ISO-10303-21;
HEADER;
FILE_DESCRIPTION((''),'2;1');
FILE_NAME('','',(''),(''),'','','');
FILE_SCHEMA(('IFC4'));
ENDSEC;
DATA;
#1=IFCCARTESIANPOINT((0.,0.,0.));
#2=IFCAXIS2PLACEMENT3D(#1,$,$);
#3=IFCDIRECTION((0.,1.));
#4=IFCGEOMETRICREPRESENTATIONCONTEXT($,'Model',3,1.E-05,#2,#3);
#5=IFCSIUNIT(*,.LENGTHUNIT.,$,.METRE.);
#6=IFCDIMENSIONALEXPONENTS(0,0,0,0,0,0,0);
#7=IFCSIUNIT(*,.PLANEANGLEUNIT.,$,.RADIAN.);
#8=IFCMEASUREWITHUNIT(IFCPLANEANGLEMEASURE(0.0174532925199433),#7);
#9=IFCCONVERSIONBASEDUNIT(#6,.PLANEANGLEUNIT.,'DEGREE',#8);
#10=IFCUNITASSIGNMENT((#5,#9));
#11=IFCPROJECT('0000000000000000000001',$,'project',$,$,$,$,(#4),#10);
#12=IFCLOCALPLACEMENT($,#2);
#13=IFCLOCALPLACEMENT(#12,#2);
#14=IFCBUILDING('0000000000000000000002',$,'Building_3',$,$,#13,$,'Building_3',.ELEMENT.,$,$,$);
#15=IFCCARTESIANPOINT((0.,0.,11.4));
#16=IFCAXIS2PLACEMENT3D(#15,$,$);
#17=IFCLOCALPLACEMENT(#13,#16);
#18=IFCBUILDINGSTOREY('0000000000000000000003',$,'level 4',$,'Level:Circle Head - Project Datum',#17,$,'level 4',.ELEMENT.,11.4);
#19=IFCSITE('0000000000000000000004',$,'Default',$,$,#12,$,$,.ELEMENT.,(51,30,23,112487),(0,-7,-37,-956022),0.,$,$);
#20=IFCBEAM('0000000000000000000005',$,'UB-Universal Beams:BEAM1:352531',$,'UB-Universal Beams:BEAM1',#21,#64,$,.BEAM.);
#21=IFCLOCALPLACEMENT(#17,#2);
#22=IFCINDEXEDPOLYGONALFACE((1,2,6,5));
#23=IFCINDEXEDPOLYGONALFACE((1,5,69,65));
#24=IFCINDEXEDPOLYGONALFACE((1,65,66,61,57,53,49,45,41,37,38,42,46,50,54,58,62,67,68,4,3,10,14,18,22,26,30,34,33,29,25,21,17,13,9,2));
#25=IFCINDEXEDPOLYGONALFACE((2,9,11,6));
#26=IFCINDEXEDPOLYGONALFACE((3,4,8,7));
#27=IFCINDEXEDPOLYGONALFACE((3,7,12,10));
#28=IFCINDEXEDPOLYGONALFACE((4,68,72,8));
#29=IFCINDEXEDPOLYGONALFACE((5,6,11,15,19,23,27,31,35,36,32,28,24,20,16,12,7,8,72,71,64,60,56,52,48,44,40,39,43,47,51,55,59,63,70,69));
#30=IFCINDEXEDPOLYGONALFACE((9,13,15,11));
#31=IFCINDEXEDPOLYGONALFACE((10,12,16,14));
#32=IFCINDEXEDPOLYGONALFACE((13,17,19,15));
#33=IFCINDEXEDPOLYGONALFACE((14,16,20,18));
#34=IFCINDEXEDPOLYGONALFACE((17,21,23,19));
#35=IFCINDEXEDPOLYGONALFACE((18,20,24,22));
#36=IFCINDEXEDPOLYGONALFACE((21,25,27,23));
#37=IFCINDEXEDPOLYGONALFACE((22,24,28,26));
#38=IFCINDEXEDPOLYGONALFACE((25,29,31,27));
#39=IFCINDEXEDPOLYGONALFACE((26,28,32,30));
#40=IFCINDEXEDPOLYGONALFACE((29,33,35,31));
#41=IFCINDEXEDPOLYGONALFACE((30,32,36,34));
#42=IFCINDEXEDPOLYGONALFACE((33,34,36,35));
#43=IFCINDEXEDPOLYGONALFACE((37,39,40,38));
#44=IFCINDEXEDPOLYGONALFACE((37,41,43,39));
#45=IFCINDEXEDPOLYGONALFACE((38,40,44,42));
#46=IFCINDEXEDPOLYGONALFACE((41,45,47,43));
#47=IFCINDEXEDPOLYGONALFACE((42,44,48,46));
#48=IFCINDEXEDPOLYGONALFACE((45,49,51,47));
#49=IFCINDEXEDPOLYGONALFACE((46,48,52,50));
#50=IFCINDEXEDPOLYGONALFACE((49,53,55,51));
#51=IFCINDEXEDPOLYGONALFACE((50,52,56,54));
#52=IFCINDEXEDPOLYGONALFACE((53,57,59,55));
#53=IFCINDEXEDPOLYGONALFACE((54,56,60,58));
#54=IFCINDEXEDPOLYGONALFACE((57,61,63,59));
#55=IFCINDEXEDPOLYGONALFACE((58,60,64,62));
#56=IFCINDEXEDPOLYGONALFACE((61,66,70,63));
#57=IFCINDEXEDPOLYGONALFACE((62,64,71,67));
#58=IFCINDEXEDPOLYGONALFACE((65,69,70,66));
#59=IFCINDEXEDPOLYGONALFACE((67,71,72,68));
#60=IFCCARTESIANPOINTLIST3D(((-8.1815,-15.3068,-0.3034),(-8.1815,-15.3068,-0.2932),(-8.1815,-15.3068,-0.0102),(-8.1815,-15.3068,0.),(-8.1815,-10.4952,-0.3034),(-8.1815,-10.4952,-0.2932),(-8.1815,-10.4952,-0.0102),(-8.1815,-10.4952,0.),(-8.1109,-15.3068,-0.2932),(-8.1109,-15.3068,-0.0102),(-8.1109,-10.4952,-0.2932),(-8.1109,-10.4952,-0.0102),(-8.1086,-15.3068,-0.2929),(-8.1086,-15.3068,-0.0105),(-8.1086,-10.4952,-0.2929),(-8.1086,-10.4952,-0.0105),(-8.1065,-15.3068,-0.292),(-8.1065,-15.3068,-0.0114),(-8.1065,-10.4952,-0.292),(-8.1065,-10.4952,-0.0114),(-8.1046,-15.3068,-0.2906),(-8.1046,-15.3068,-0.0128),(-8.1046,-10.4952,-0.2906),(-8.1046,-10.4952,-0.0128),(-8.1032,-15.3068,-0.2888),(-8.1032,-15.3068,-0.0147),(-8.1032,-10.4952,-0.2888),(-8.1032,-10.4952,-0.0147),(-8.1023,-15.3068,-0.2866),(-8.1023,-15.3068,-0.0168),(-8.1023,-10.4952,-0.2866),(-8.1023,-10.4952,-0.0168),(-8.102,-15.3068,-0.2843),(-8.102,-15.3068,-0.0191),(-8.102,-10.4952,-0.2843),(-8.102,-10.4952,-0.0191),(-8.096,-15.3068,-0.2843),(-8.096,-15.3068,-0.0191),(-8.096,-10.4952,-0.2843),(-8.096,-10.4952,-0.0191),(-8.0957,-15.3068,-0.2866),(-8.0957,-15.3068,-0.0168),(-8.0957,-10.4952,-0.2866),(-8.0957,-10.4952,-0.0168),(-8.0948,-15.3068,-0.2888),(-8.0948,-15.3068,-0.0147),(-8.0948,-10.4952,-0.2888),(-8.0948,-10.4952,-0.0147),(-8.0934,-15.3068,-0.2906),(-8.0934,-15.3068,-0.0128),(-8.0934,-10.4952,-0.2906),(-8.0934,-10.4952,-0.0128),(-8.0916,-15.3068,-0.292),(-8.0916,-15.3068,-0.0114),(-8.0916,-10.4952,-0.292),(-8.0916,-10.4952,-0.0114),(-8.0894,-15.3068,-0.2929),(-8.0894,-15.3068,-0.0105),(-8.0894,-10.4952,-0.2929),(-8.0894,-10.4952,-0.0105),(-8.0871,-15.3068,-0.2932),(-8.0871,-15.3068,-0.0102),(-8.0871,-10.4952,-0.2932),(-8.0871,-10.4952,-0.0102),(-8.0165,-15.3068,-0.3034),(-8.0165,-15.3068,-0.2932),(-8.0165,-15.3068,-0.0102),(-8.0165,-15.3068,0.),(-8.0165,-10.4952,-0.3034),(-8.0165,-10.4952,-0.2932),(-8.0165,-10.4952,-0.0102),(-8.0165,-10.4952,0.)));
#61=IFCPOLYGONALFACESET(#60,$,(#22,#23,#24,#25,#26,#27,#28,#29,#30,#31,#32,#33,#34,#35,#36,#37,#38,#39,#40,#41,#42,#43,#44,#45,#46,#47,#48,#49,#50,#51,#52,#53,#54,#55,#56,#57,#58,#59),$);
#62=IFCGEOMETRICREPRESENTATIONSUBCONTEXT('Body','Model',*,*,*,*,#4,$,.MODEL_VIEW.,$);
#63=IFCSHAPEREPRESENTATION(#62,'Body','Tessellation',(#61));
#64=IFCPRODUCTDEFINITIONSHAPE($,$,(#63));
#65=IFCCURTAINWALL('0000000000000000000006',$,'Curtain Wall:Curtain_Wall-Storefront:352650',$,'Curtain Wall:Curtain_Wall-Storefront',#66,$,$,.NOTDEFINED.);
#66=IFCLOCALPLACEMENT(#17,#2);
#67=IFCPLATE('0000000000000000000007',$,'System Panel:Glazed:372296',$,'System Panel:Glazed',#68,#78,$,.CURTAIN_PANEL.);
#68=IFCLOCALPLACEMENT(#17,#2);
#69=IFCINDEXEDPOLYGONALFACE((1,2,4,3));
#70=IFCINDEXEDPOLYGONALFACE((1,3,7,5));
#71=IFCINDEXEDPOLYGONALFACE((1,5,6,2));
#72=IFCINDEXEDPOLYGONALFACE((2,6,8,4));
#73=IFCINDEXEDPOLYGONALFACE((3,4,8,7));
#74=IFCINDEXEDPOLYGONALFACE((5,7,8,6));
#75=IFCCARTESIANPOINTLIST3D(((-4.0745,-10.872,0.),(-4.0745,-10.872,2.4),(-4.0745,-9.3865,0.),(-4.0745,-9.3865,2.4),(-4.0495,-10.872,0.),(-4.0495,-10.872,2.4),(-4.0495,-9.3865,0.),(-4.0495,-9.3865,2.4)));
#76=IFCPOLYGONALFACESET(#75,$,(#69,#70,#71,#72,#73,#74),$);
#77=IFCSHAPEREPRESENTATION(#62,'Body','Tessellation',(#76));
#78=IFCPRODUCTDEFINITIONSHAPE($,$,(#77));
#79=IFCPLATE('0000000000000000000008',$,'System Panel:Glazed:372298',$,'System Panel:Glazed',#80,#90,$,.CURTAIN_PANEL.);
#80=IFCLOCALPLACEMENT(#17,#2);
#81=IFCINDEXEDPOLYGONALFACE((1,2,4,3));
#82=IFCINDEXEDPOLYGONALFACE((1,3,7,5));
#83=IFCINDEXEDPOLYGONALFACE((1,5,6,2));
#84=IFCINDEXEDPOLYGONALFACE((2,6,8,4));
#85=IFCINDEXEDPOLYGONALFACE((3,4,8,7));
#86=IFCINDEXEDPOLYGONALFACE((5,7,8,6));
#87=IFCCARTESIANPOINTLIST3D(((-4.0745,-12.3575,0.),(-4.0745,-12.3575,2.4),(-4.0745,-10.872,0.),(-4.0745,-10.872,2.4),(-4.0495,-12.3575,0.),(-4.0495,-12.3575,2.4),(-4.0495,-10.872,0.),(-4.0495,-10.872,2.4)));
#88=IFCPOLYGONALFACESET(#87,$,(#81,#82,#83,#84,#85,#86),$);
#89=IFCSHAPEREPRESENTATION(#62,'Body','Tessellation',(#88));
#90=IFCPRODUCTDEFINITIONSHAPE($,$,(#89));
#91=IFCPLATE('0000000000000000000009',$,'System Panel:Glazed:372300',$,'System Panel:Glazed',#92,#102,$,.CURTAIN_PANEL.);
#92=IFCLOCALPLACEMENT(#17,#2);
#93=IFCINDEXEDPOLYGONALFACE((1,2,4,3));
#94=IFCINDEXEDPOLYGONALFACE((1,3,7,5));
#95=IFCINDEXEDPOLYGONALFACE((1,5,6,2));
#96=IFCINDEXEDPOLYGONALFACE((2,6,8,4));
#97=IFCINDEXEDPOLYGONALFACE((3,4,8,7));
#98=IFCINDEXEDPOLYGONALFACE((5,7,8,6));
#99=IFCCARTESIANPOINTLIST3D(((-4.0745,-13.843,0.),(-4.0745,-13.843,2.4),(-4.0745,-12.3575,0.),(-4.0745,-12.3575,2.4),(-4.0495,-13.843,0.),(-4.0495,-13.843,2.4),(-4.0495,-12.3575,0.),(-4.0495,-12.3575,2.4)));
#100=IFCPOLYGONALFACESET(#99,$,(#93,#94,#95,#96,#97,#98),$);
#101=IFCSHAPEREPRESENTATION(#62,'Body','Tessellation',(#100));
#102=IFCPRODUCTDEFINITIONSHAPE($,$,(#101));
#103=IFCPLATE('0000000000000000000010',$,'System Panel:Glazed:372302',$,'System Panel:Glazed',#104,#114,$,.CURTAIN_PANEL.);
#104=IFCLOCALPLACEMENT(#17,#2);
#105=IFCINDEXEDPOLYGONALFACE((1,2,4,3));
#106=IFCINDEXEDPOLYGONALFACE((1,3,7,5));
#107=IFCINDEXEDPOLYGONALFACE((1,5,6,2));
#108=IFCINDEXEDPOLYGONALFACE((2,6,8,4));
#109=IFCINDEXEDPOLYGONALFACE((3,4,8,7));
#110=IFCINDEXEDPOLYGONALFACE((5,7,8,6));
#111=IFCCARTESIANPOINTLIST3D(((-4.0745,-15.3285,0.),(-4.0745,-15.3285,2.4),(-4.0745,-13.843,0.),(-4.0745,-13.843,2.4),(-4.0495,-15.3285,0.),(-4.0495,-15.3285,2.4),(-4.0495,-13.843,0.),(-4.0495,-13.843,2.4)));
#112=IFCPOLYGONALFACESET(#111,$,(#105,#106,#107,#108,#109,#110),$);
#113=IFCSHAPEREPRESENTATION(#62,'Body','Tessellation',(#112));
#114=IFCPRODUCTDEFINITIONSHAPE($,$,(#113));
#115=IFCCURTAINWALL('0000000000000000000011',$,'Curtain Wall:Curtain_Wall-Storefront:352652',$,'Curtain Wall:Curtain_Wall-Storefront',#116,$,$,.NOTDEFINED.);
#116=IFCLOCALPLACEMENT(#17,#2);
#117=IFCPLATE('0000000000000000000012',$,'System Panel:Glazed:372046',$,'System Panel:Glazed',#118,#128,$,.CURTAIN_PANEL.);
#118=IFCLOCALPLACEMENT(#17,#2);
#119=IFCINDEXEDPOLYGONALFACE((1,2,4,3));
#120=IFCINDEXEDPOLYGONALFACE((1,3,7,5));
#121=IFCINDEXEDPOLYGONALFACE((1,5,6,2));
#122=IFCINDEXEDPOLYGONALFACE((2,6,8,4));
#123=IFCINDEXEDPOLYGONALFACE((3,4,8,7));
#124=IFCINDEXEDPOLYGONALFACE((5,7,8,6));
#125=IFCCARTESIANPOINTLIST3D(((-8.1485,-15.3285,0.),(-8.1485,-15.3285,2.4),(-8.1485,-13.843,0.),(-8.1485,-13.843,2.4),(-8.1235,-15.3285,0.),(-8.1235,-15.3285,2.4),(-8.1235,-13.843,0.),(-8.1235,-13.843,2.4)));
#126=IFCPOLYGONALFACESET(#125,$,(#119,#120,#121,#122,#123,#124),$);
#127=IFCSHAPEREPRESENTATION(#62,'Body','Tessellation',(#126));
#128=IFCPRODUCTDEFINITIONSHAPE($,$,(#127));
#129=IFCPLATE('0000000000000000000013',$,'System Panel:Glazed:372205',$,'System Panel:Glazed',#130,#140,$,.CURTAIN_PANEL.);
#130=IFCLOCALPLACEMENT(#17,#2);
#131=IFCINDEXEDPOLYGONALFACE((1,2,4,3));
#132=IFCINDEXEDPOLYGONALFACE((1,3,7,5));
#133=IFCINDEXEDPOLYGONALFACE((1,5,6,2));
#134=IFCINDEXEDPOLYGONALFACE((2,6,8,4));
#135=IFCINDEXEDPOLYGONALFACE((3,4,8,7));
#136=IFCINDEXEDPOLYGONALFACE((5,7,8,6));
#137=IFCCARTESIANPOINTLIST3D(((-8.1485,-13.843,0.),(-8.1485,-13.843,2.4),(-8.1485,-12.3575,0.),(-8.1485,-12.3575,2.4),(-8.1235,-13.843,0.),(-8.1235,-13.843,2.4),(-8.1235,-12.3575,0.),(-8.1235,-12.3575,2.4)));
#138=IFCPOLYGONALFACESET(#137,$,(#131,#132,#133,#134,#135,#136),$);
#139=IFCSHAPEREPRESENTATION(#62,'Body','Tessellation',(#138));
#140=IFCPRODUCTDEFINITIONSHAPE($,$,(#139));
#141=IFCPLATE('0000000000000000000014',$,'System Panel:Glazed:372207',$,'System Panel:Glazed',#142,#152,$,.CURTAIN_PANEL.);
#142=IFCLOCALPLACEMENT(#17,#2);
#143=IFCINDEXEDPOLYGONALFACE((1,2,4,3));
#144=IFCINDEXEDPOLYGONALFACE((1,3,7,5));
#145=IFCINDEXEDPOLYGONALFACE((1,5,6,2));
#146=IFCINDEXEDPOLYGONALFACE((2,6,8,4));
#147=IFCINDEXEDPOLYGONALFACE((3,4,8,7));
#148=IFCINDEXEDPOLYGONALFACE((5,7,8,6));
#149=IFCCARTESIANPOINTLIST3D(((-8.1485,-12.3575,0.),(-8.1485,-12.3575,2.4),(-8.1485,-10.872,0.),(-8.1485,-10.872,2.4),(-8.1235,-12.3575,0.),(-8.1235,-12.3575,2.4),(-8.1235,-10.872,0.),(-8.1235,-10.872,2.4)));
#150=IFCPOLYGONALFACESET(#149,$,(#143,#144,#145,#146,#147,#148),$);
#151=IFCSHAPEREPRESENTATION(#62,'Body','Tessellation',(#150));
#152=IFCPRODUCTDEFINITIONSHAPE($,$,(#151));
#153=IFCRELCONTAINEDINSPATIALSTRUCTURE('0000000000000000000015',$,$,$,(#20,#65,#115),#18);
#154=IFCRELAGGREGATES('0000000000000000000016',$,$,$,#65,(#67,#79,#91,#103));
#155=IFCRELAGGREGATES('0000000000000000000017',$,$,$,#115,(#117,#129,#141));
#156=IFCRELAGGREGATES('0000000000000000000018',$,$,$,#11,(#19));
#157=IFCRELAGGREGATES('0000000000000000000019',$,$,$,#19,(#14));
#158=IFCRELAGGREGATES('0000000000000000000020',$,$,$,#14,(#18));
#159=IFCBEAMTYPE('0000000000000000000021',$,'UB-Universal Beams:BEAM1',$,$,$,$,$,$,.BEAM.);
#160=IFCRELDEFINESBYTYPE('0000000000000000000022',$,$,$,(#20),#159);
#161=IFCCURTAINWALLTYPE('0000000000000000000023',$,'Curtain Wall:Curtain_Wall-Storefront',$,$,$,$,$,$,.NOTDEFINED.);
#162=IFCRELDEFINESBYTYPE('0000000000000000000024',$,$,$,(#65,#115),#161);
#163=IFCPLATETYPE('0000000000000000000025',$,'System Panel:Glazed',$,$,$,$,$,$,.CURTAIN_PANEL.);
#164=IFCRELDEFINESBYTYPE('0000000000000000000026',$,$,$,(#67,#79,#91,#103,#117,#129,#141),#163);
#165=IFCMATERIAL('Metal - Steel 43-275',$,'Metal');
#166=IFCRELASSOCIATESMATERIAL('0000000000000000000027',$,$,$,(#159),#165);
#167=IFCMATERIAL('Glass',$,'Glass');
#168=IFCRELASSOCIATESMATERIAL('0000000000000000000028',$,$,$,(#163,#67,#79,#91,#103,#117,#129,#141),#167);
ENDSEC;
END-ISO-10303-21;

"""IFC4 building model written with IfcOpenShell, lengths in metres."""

from ifc_helpers import new_model, entity, si_unit, converted_unit, direction, frame, frame_2d, origin, origin_2d_with_axis, place, context, subcontext, project, spatial, polyline, circle_curve, parameter, trimmed, segment, composite_curve, rectangle, outline, extrude, source, transform, mapped, material, material_profile, profile_set, type_object, type_shapes, element, aggregate, save


model = new_model("IFC4")

# Units and contexts
model_context = context("Model", 3, precision=1e-05, world=origin(), true_north=direction((0.0, 1.0)))
body_context = subcontext(model_context, "Body", "Model", "MODEL_VIEW")
ifc_project = project(units=[si_unit("LENGTHUNIT", "METRE"), converted_unit("PLANEANGLEUNIT", "DEGREE", entity("IfcPlaneAngleMeasure", 0.0174532925199433), si_unit("PLANEANGLEUNIT", "RADIAN"), dimensions=[0, 0, 0, 0, 0, 0, 0])], contexts=[model_context])

# Site, building, storey
site_placement = place(None, origin())
site = spatial("IfcSite", under=ifc_project, at=site_placement, Name="Default", CompositionType="ELEMENT", RefLatitude=(51, 30, 23, 112487), RefLongitude=(0, -7, -37, -956022), RefElevation=0.0)
building_placement = place(site_placement, origin())
building = spatial("IfcBuilding", under=site, at=building_placement, Name="Building_3", LongName="Building_3", CompositionType="ELEMENT")
storey_placement = place(building_placement, frame((0.0, 0.0, 11.4)))
storey = spatial("IfcBuildingStorey", under=building, at=storey_placement, Name="level 4", ObjectType="Level:Circle Head - Project Datum", LongName="level 4", CompositionType="ELEMENT", Elevation=11.4)

# Shared definitions
ifc_material_1 = material(Name="Metal - Steel 43-275", Category="Metal")

# Beam
ifc_material_profile_1 = material_profile(ifc_material_1, outline(composite_curve([segment(polyline([(-0.0825, -0.1415), (-0.0825, -0.1517)]), True, "CONTINUOUS"), segment(polyline([(-0.0825, -0.1517), (0.0825, -0.1517)]), True, "CONTINUOUS"), segment(polyline([(0.0825, -0.1517), (0.0825, -0.1415)]), True, "CONTINUOUS"), segment(polyline([(0.0825, -0.1415), (0.0119, -0.1415)]), True, "CONTINUOUS"), segment(trimmed(circle_curve(frame_2d((0.0119, -0.1326), x_axis=(1.0, 0.0)), 0.0089), [parameter(180.0)], [parameter(270.0)], True, "PARAMETER"), False, "CONTINUOUS"), segment(polyline([(0.003, -0.1326), (0.003, 0.1326)]), True, "CONTINUOUS"), segment(trimmed(circle_curve(frame_2d((0.0119, 0.1326), x_axis=(1.0, 0.0)), 0.0089), [parameter(90.0)], [parameter(180.0)], True, "PARAMETER"), False, "CONTINUOUS"), segment(polyline([(0.0119, 0.1415), (0.0825, 0.1415)]), True, "CONTINUOUS"), segment(polyline([(0.0825, 0.1415), (0.0825, 0.1517)]), True, "CONTINUOUS"), segment(polyline([(0.0825, 0.1517), (-0.0825, 0.1517)]), True, "CONTINUOUS"), segment(polyline([(-0.0825, 0.1517), (-0.0825, 0.1415)]), True, "CONTINUOUS"), segment(polyline([(-0.0825, 0.1415), (-0.0119, 0.1415)]), True, "CONTINUOUS"), segment(trimmed(circle_curve(frame_2d((-0.0119, 0.1326), x_axis=(1.0, 0.0)), 0.0089), [parameter(360.0)], [parameter(90.0)], True, "PARAMETER"), False, "CONTINUOUS"), segment(polyline([(-0.003, 0.1326), (-0.003, -0.1326)]), True, "CONTINUOUS"), segment(trimmed(circle_curve(frame_2d((-0.0119, -0.1326), x_axis=(1.0, 0.0)), 0.0089), [parameter(270.0)], [parameter(360.0)], True, "PARAMETER"), False, "CONTINUOUS"), segment(polyline([(-0.0119, -0.1415), (-0.0825, -0.1415)]), True, "CONTINUOUS")], self_intersect=False)), Name="BEAM1")
ifc_profile_set_1 = profile_set([ifc_material_profile_1], Name="BEAM1")
beam_type_1 = type_object("IfcBeamType", Name="UB-Universal Beams:BEAM1", PredefinedType="BEAM", material=ifc_profile_set_1)
shared_shape_1 = source(origin(), body_context, "Body", "SweptSolid", [
    extrude(outline(composite_curve([segment(polyline([(-0.0825, -0.1415), (-0.0825, -0.1517)]), True, "CONTINUOUS"), segment(polyline([(-0.0825, -0.1517), (0.0825, -0.1517)]), True, "CONTINUOUS"), segment(polyline([(0.0825, -0.1517), (0.0825, -0.1415)]), True, "CONTINUOUS"), segment(polyline([(0.0825, -0.1415), (0.0119, -0.1415)]), True, "CONTINUOUS"), segment(trimmed(circle_curve(frame_2d((0.0119, -0.1326), x_axis=(0.0, -1.0)), 0.0089), [parameter(270.0)], [parameter(360.0)], True, "PARAMETER"), False, "CONTINUOUS"), segment(polyline([(0.003, -0.1326), (0.003, 0.1326)]), True, "CONTINUOUS"), segment(trimmed(circle_curve(frame_2d((0.0119, 0.1326), x_axis=(-1.0, 0.0)), 0.0089), [parameter(270.0)], [parameter(360.0)], True, "PARAMETER"), False, "CONTINUOUS"), segment(polyline([(0.0119, 0.1415), (0.0825, 0.1415)]), True, "CONTINUOUS"), segment(polyline([(0.0825, 0.1415), (0.0825, 0.1517)]), True, "CONTINUOUS"), segment(polyline([(0.0825, 0.1517), (-0.0825, 0.1517)]), True, "CONTINUOUS"), segment(polyline([(-0.0825, 0.1517), (-0.0825, 0.1415)]), True, "CONTINUOUS"), segment(polyline([(-0.0825, 0.1415), (-0.0119, 0.1415)]), True, "CONTINUOUS"), segment(trimmed(circle_curve(frame_2d((-0.0119, 0.1326), x_axis=(0.0, 1.0)), 0.0089), [parameter(270.0)], [parameter(360.0)], True, "PARAMETER"), False, "CONTINUOUS"), segment(polyline([(-0.003, 0.1326), (-0.003, -0.1326)]), True, "CONTINUOUS"), segment(trimmed(circle_curve(frame_2d((-0.0119, -0.1326), x_axis=(1.0, 0.0)), 0.0089), [parameter(270.0)], [parameter(0.0)], True, "PARAMETER"), False, "CONTINUOUS"), segment(polyline([(-0.0119, -0.1415), (-0.0825, -0.1415)]), True, "CONTINUOUS")], self_intersect=False)), frame((-2.4058, 0.0, 0.0), z_axis=(-1.0, 0.0, 0.0), x_axis=(0.0, -1.0, 0.0)), (0.0, 0.0, -1.0), 4.8116),
])
type_shapes(beam_type_1, [shared_shape_1])
for number, where, z_axis, x_axis, name in (
    (1, (-8.099, -12.901, -0.1517), (0.0, 0.0, 1.0), (0.0, 1.0, 0.0), "UB-Universal Beams:BEAM1:352531"),
):
    element("IfcBeam", number, at=place(storey_placement, frame(where, z_axis=z_axis, x_axis=x_axis)), inside=storey, type_object=beam_type_1, Name=name, ObjectType="UB-Universal Beams:BEAM1", PredefinedType="BEAM", context=body_context, shape_type="MappedRepresentation", body=[
        mapped(shared_shape_1, transform((0.0, 0.0, 0.0), scale=1.0)),
    ])

# Curtain walls, plates
curtain_wall_type = type_object("IfcCurtainWallType", Name="Curtain Wall:Curtain_Wall-Storefront", PredefinedType="NOTDEFINED")
curtain_wall_1_placement = place(storey_placement, frame((0.0, 0.0, -11.4)))
curtain_wall_1 = element("IfcCurtainWall", 2, at=curtain_wall_1_placement, inside=storey, type_object=curtain_wall_type, Name="Curtain Wall:Curtain_Wall-Storefront:352650", ObjectType="Curtain Wall:Curtain_Wall-Storefront", PredefinedType="NOTDEFINED")
ifc_material_2 = material(Name="Glass", Category="Glass")
plate_type_1 = type_object("IfcPlateType", Name="System Panel:Glazed", PredefinedType="CURTAIN_PANEL", material=ifc_material_2)
shared_shape_2 = source(origin(), body_context, "Body", "SweptSolid", [
    extrude(rectangle(XDim=0.025, YDim=1.4855, at=origin_2d_with_axis()), frame((0.7428, 0.0125, 0.0), z_axis=(0.0, 0.0, 1.0), x_axis=(0.0, 1.0, 0.0)), (0.0, 0.0, 1.0), 2.4),
])
type_shapes(plate_type_1, [shared_shape_2])
plate_1_placement = place(curtain_wall_1_placement, frame((-4.0745, -9.3865, 11.4), z_axis=(0.0, 0.0, 1.0), x_axis=(0.0, -1.0, 0.0)))
plate_1 = element("IfcPlate", 3, at=plate_1_placement, type_object=plate_type_1, material=ifc_material_2, Name="System Panel:Glazed:372296", ObjectType="System Panel:Glazed", PredefinedType="CURTAIN_PANEL", context=body_context, shape_type="MappedRepresentation", body=[
    mapped(shared_shape_2, transform((0.0, 0.0, 0.0), scale=1.0)),
])
plate_2_placement = place(curtain_wall_1_placement, frame((-4.0745, -10.872, 11.4), z_axis=(0.0, 0.0, 1.0), x_axis=(0.0, -1.0, 0.0)))
plate_2 = element("IfcPlate", 4, at=plate_2_placement, type_object=plate_type_1, material=ifc_material_2, Name="System Panel:Glazed:372298", ObjectType="System Panel:Glazed", PredefinedType="CURTAIN_PANEL", context=body_context, shape_type="MappedRepresentation", body=[
    mapped(shared_shape_2, transform((0.0, 0.0, 0.0), scale=1.0)),
])
plate_3_placement = place(curtain_wall_1_placement, frame((-4.0745, -12.3575, 11.4), z_axis=(0.0, 0.0, 1.0), x_axis=(0.0, -1.0, 0.0)))
plate_3 = element("IfcPlate", 5, at=plate_3_placement, type_object=plate_type_1, material=ifc_material_2, Name="System Panel:Glazed:372300", ObjectType="System Panel:Glazed", PredefinedType="CURTAIN_PANEL", context=body_context, shape_type="MappedRepresentation", body=[
    mapped(shared_shape_2, transform((0.0, 0.0, 0.0), scale=1.0)),
])
plate_4_placement = place(curtain_wall_1_placement, frame((-4.0745, -13.843, 11.4), z_axis=(0.0, 0.0, 1.0), x_axis=(0.0, -1.0, 0.0)))
plate_4 = element("IfcPlate", 6, at=plate_4_placement, type_object=plate_type_1, material=ifc_material_2, Name="System Panel:Glazed:372302", ObjectType="System Panel:Glazed", PredefinedType="CURTAIN_PANEL", context=body_context, shape_type="MappedRepresentation", body=[
    mapped(shared_shape_2, transform((0.0, 0.0, 0.0), scale=1.0)),
])
aggregate(curtain_wall_1, [plate_1, plate_2, plate_3, plate_4])
curtain_wall_2_placement = place(storey_placement, frame((0.0, 0.0, -11.4)))
curtain_wall_2 = element("IfcCurtainWall", 7, at=curtain_wall_2_placement, inside=storey, type_object=curtain_wall_type, Name="Curtain Wall:Curtain_Wall-Storefront:352652", ObjectType="Curtain Wall:Curtain_Wall-Storefront", PredefinedType="NOTDEFINED")
plate_5_placement = place(curtain_wall_2_placement, frame((-8.1235, -15.3285, 11.4), z_axis=(0.0, 0.0, 1.0), x_axis=(0.0, 1.0, 0.0)))
plate_5 = element("IfcPlate", 8, at=plate_5_placement, type_object=plate_type_1, material=ifc_material_2, Name="System Panel:Glazed:372046", ObjectType="System Panel:Glazed", PredefinedType="CURTAIN_PANEL", context=body_context, shape_type="MappedRepresentation", body=[
    mapped(shared_shape_2, transform((0.0, 0.0, 0.0), scale=1.0)),
])
plate_6_placement = place(curtain_wall_2_placement, frame((-8.1235, -13.843, 11.4), z_axis=(0.0, 0.0, 1.0), x_axis=(0.0, 1.0, 0.0)))
plate_6 = element("IfcPlate", 9, at=plate_6_placement, type_object=plate_type_1, material=ifc_material_2, Name="System Panel:Glazed:372205", ObjectType="System Panel:Glazed", PredefinedType="CURTAIN_PANEL", context=body_context, shape_type="MappedRepresentation", body=[
    mapped(shared_shape_2, transform((0.0, 0.0, 0.0), scale=1.0)),
])
plate_7_placement = place(curtain_wall_2_placement, frame((-8.1235, -12.3575, 11.4), z_axis=(0.0, 0.0, 1.0), x_axis=(0.0, 1.0, 0.0)))
plate_7 = element("IfcPlate", 10, at=plate_7_placement, type_object=plate_type_1, material=ifc_material_2, Name="System Panel:Glazed:372207", ObjectType="System Panel:Glazed", PredefinedType="CURTAIN_PANEL", context=body_context, shape_type="MappedRepresentation", body=[
    mapped(shared_shape_2, transform((0.0, 0.0, 0.0), scale=1.0)),
])
aggregate(curtain_wall_2, [plate_5, plate_6, plate_7])

save(model, "model.ifc")
